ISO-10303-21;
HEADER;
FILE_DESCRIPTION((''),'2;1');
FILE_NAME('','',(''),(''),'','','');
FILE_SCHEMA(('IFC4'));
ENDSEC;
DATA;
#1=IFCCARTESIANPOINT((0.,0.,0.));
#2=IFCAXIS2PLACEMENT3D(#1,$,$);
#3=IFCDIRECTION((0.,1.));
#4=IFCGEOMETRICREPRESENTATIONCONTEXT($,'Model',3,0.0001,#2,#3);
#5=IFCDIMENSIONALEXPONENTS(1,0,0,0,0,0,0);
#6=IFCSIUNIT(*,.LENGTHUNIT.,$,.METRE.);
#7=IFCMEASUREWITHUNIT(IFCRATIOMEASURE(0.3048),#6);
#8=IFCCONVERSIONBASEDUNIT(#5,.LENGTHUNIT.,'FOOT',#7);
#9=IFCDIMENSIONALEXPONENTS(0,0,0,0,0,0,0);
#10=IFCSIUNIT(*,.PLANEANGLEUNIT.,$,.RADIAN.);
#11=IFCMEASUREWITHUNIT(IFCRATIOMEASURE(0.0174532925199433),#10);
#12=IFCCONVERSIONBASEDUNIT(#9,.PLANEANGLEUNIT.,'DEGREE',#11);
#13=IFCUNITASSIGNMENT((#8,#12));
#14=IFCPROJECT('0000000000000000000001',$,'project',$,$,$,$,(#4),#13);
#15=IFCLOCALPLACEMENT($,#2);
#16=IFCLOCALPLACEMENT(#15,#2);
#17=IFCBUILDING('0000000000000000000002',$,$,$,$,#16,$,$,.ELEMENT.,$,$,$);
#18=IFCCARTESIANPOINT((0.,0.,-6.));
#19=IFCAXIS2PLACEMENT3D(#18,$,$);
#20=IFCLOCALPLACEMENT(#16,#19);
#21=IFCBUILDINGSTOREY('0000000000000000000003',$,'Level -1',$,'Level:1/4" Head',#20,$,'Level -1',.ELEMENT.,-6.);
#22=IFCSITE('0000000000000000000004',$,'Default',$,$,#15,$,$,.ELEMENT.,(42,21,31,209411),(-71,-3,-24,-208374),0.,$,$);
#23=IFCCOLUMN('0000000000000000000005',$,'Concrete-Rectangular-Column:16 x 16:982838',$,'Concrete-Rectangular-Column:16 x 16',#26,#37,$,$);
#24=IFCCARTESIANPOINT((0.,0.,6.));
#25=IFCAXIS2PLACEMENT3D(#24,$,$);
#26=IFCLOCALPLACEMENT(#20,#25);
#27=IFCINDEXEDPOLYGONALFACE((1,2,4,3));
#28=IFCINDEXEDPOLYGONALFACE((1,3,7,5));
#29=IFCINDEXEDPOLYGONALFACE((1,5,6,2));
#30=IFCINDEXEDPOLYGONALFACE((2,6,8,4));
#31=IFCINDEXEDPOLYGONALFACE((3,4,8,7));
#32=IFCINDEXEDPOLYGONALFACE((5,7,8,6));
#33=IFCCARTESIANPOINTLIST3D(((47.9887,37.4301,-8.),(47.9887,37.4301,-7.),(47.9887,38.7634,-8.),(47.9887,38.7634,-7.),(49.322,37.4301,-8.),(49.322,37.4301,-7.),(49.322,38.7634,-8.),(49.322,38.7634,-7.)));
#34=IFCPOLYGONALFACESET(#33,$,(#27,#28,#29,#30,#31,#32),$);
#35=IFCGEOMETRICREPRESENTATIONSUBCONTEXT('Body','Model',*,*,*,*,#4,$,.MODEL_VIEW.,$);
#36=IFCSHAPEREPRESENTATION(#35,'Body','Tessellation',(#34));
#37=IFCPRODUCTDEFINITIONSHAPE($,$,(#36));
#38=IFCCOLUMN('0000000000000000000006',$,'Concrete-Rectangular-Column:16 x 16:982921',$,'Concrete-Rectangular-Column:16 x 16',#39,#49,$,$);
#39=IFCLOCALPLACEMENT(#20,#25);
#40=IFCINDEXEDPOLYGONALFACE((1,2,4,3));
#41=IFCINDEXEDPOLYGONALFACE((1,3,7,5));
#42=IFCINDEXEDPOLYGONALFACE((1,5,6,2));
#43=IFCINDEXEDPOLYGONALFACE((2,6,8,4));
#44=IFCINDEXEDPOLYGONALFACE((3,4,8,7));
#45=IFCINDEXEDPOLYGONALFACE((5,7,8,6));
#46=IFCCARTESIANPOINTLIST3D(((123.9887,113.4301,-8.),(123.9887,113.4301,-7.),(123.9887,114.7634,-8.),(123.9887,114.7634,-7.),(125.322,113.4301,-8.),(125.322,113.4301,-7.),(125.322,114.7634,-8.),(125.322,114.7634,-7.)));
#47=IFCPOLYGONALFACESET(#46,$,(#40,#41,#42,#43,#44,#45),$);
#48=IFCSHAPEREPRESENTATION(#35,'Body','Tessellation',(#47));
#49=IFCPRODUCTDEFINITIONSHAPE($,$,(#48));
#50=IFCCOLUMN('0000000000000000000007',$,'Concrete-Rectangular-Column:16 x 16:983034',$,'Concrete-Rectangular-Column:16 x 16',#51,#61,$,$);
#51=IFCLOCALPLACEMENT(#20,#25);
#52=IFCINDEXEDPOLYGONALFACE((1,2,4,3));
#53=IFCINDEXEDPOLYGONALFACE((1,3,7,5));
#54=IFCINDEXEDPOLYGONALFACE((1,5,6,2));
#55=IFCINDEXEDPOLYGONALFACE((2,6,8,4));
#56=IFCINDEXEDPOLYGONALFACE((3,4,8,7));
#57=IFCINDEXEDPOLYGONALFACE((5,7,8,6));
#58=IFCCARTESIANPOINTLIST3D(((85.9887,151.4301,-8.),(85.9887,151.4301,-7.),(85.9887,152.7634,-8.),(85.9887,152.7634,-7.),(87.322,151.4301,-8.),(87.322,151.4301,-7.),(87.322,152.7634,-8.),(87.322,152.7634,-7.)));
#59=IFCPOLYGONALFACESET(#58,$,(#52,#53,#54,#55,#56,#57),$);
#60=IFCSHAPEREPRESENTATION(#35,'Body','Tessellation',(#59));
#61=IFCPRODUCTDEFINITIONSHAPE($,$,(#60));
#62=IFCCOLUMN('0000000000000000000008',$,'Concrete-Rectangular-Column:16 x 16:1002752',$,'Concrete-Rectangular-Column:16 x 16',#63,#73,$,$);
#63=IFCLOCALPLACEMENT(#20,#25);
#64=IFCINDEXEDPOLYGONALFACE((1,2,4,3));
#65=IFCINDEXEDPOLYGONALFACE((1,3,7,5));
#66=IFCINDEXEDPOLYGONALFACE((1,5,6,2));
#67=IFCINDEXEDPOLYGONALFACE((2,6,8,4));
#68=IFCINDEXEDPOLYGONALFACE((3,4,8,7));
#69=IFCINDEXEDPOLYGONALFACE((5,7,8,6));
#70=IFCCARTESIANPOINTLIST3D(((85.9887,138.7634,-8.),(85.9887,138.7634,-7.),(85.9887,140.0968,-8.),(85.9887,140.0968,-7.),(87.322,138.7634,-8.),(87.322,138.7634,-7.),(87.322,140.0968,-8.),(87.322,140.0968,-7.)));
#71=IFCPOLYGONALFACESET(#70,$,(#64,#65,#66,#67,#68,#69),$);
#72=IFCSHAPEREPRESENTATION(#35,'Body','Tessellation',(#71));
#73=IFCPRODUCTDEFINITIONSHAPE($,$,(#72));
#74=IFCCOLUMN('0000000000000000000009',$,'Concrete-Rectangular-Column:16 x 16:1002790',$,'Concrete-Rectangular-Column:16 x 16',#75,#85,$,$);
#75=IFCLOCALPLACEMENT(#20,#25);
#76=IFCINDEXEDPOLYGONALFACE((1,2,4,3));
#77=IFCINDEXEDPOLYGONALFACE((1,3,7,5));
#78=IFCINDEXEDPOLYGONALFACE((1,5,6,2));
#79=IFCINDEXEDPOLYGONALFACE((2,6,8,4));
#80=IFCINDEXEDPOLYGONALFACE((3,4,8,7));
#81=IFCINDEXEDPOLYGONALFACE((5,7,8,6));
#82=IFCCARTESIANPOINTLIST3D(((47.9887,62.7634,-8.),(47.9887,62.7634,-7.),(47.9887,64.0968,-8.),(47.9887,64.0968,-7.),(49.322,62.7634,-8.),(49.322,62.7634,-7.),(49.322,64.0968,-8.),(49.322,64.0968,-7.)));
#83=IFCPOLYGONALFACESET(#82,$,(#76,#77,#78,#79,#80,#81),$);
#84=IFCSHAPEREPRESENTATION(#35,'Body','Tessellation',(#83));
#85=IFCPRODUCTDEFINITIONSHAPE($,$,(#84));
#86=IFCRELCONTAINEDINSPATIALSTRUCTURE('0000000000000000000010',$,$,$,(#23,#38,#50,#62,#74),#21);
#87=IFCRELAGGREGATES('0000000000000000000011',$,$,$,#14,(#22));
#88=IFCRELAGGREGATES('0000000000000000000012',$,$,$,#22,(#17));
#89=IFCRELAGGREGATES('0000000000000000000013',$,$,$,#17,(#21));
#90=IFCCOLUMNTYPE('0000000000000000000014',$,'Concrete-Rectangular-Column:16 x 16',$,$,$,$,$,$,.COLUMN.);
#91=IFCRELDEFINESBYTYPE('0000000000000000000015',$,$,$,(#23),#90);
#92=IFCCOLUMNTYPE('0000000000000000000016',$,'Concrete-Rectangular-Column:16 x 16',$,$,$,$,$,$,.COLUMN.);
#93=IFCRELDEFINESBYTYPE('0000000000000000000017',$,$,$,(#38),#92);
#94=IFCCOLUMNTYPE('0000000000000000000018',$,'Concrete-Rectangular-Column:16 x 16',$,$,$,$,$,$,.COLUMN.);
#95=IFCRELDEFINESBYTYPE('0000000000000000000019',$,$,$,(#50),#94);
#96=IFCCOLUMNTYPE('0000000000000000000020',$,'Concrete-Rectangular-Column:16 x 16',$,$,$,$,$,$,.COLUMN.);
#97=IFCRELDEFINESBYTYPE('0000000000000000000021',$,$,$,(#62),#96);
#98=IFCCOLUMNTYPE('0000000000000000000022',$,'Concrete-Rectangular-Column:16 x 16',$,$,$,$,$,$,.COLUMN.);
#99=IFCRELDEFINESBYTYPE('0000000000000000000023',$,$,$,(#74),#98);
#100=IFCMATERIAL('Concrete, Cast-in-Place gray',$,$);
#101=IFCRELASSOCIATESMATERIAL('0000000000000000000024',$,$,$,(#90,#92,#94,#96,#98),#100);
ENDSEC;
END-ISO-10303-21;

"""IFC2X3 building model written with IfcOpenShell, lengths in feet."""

from ifc_helpers import new_model, entity, si_unit, converted_unit, direction, frame, frame_2d, origin, origin_2d_with_axis, place, context, subcontext, project, spatial, rectangle, extrude, source, transform, mapped, material, type_object, type_shapes, element, save


model = new_model("IFC2X3")

# Units and contexts
model_context = context("Model", 3, precision=0.0001, world=origin(), true_north=direction((0.0, 1.0)))
body_context = subcontext(model_context, "Body", "Model", "MODEL_VIEW")
ifc_project = project(units=[converted_unit("LENGTHUNIT", "FOOT", entity("IfcRatioMeasure", 0.3048), si_unit("LENGTHUNIT", "METRE"), dimensions=[1, 0, 0, 0, 0, 0, 0]), converted_unit("PLANEANGLEUNIT", "DEGREE", entity("IfcRatioMeasure", 0.0174532925199433), si_unit("PLANEANGLEUNIT", "RADIAN"), dimensions=[0, 0, 0, 0, 0, 0, 0])], contexts=[model_context])

# Site, building, storey
site_placement = place(None, origin())
site = spatial("IfcSite", under=ifc_project, at=site_placement, Name="Default", CompositionType="ELEMENT", RefLatitude=(42, 21, 31, 209411), RefLongitude=(-71, -3, -24, -208374), RefElevation=0.0)
building_placement = place(site_placement, origin())
building = spatial("IfcBuilding", under=site, at=building_placement, CompositionType="ELEMENT")
storey_placement = place(building_placement, frame((0.0, 0.0, -6.0)))
storey = spatial("IfcBuildingStorey", under=building, at=storey_placement, Name="Level -1", ObjectType="Level:1/4\" Head", LongName="Level -1", CompositionType="ELEMENT", Elevation=-6.0)

# Columns
ifc_material_1 = material(Name="Concrete, Cast-in-Place gray")
column_type_1 = type_object("IfcColumnType", Name="Concrete-Rectangular-Column:16 x 16", PredefinedType="COLUMN", material=ifc_material_1)
shared_shape_1 = source(origin(), body_context, "Body", "SweptSolid", [
    extrude(rectangle(XDim=1.3333, YDim=1.3333, at=frame_2d((0.0, 0.0), x_axis=(1.0, 0.0))), frame((48.6554, 38.0968, -8.0), z_axis=(0.0, 0.0, 1.0), x_axis=(0.0, -1.0, 0.0)), (0.0, 0.0, 1.0), 1.0),
])
type_shapes(column_type_1, [shared_shape_1])
column_1_placement = place(storey_placement, frame((0.0, 0.0, 6.0)))
element("IfcColumn", 1, at=column_1_placement, inside=storey, type_object=column_type_1, Name="Concrete-Rectangular-Column:16 x 16:982838", ObjectType="Concrete-Rectangular-Column:16 x 16", context=body_context, shape_type="MappedRepresentation", body=[
    mapped(shared_shape_1, transform((0.0, 0.0, 0.0), scale=1.0)),
])
column_type_2 = type_object("IfcColumnType", Name="Concrete-Rectangular-Column:16 x 16", PredefinedType="COLUMN", material=ifc_material_1)
shared_shape_2 = source(origin(), body_context, "Body", "SweptSolid", [
    extrude(rectangle(XDim=1.3333, YDim=1.3333, at=origin_2d_with_axis()), frame((124.6554, 114.0968, -8.0), z_axis=(0.0, 0.0, 1.0), x_axis=(0.0, -1.0, 0.0)), (0.0, 0.0, 1.0), 1.0),
])
type_shapes(column_type_2, [shared_shape_2])
column_2_placement = place(storey_placement, frame((0.0, 0.0, 6.0)))
element("IfcColumn", 2, at=column_2_placement, inside=storey, type_object=column_type_2, Name="Concrete-Rectangular-Column:16 x 16:982921", ObjectType="Concrete-Rectangular-Column:16 x 16", context=body_context, shape_type="MappedRepresentation", body=[
    mapped(shared_shape_2, transform((0.0, 0.0, 0.0), scale=1.0)),
])
column_type_3 = type_object("IfcColumnType", Name="Concrete-Rectangular-Column:16 x 16", PredefinedType="COLUMN", material=ifc_material_1)
shared_shape_3 = source(origin(), body_context, "Body", "SweptSolid", [
    extrude(rectangle(XDim=1.3333, YDim=1.3333, at=origin_2d_with_axis()), frame((86.6554, 152.0968, -8.0), z_axis=(0.0, 0.0, 1.0), x_axis=(0.0, -1.0, 0.0)), (0.0, 0.0, 1.0), 1.0),
])
type_shapes(column_type_3, [shared_shape_3])
column_3_placement = place(storey_placement, frame((0.0, 0.0, 6.0)))
element("IfcColumn", 3, at=column_3_placement, inside=storey, type_object=column_type_3, Name="Concrete-Rectangular-Column:16 x 16:983034", ObjectType="Concrete-Rectangular-Column:16 x 16", context=body_context, shape_type="MappedRepresentation", body=[
    mapped(shared_shape_3, transform((0.0, 0.0, 0.0), scale=1.0)),
])
column_type_4 = type_object("IfcColumnType", Name="Concrete-Rectangular-Column:16 x 16", PredefinedType="COLUMN", material=ifc_material_1)
shared_shape_4 = source(origin(), body_context, "Body", "SweptSolid", [
    extrude(rectangle(XDim=1.3333, YDim=1.3333, at=frame_2d((0.0, 0.0), x_axis=(1.0, 0.0))), frame((86.6554, 139.4301, -8.0), z_axis=(0.0, 0.0, 1.0), x_axis=(0.0, -1.0, 0.0)), (0.0, 0.0, 1.0), 1.0),
])
type_shapes(column_type_4, [shared_shape_4])
column_4_placement = place(storey_placement, frame((0.0, 0.0, 6.0)))
element("IfcColumn", 4, at=column_4_placement, inside=storey, type_object=column_type_4, Name="Concrete-Rectangular-Column:16 x 16:1002752", ObjectType="Concrete-Rectangular-Column:16 x 16", context=body_context, shape_type="MappedRepresentation", body=[
    mapped(shared_shape_4, transform((0.0, 0.0, 0.0), scale=1.0)),
])
column_type_5 = type_object("IfcColumnType", Name="Concrete-Rectangular-Column:16 x 16", PredefinedType="COLUMN", material=ifc_material_1)
shared_shape_5 = source(origin(), body_context, "Body", "SweptSolid", [
    extrude(rectangle(XDim=1.3333, YDim=1.3333, at=frame_2d((0.0, 0.0), x_axis=(1.0, 0.0))), frame((48.6554, 63.4301, -8.0), z_axis=(0.0, 0.0, 1.0), x_axis=(0.0, -1.0, 0.0)), (0.0, 0.0, 1.0), 1.0),
])
type_shapes(column_type_5, [shared_shape_5])
column_5_placement = place(storey_placement, frame((0.0, 0.0, 6.0)))
element("IfcColumn", 5, at=column_5_placement, inside=storey, type_object=column_type_5, Name="Concrete-Rectangular-Column:16 x 16:1002790", ObjectType="Concrete-Rectangular-Column:16 x 16", context=body_context, shape_type="MappedRepresentation", body=[
    mapped(shared_shape_5, transform((0.0, 0.0, 0.0), scale=1.0)),
])

save(model, "model.ifc")
